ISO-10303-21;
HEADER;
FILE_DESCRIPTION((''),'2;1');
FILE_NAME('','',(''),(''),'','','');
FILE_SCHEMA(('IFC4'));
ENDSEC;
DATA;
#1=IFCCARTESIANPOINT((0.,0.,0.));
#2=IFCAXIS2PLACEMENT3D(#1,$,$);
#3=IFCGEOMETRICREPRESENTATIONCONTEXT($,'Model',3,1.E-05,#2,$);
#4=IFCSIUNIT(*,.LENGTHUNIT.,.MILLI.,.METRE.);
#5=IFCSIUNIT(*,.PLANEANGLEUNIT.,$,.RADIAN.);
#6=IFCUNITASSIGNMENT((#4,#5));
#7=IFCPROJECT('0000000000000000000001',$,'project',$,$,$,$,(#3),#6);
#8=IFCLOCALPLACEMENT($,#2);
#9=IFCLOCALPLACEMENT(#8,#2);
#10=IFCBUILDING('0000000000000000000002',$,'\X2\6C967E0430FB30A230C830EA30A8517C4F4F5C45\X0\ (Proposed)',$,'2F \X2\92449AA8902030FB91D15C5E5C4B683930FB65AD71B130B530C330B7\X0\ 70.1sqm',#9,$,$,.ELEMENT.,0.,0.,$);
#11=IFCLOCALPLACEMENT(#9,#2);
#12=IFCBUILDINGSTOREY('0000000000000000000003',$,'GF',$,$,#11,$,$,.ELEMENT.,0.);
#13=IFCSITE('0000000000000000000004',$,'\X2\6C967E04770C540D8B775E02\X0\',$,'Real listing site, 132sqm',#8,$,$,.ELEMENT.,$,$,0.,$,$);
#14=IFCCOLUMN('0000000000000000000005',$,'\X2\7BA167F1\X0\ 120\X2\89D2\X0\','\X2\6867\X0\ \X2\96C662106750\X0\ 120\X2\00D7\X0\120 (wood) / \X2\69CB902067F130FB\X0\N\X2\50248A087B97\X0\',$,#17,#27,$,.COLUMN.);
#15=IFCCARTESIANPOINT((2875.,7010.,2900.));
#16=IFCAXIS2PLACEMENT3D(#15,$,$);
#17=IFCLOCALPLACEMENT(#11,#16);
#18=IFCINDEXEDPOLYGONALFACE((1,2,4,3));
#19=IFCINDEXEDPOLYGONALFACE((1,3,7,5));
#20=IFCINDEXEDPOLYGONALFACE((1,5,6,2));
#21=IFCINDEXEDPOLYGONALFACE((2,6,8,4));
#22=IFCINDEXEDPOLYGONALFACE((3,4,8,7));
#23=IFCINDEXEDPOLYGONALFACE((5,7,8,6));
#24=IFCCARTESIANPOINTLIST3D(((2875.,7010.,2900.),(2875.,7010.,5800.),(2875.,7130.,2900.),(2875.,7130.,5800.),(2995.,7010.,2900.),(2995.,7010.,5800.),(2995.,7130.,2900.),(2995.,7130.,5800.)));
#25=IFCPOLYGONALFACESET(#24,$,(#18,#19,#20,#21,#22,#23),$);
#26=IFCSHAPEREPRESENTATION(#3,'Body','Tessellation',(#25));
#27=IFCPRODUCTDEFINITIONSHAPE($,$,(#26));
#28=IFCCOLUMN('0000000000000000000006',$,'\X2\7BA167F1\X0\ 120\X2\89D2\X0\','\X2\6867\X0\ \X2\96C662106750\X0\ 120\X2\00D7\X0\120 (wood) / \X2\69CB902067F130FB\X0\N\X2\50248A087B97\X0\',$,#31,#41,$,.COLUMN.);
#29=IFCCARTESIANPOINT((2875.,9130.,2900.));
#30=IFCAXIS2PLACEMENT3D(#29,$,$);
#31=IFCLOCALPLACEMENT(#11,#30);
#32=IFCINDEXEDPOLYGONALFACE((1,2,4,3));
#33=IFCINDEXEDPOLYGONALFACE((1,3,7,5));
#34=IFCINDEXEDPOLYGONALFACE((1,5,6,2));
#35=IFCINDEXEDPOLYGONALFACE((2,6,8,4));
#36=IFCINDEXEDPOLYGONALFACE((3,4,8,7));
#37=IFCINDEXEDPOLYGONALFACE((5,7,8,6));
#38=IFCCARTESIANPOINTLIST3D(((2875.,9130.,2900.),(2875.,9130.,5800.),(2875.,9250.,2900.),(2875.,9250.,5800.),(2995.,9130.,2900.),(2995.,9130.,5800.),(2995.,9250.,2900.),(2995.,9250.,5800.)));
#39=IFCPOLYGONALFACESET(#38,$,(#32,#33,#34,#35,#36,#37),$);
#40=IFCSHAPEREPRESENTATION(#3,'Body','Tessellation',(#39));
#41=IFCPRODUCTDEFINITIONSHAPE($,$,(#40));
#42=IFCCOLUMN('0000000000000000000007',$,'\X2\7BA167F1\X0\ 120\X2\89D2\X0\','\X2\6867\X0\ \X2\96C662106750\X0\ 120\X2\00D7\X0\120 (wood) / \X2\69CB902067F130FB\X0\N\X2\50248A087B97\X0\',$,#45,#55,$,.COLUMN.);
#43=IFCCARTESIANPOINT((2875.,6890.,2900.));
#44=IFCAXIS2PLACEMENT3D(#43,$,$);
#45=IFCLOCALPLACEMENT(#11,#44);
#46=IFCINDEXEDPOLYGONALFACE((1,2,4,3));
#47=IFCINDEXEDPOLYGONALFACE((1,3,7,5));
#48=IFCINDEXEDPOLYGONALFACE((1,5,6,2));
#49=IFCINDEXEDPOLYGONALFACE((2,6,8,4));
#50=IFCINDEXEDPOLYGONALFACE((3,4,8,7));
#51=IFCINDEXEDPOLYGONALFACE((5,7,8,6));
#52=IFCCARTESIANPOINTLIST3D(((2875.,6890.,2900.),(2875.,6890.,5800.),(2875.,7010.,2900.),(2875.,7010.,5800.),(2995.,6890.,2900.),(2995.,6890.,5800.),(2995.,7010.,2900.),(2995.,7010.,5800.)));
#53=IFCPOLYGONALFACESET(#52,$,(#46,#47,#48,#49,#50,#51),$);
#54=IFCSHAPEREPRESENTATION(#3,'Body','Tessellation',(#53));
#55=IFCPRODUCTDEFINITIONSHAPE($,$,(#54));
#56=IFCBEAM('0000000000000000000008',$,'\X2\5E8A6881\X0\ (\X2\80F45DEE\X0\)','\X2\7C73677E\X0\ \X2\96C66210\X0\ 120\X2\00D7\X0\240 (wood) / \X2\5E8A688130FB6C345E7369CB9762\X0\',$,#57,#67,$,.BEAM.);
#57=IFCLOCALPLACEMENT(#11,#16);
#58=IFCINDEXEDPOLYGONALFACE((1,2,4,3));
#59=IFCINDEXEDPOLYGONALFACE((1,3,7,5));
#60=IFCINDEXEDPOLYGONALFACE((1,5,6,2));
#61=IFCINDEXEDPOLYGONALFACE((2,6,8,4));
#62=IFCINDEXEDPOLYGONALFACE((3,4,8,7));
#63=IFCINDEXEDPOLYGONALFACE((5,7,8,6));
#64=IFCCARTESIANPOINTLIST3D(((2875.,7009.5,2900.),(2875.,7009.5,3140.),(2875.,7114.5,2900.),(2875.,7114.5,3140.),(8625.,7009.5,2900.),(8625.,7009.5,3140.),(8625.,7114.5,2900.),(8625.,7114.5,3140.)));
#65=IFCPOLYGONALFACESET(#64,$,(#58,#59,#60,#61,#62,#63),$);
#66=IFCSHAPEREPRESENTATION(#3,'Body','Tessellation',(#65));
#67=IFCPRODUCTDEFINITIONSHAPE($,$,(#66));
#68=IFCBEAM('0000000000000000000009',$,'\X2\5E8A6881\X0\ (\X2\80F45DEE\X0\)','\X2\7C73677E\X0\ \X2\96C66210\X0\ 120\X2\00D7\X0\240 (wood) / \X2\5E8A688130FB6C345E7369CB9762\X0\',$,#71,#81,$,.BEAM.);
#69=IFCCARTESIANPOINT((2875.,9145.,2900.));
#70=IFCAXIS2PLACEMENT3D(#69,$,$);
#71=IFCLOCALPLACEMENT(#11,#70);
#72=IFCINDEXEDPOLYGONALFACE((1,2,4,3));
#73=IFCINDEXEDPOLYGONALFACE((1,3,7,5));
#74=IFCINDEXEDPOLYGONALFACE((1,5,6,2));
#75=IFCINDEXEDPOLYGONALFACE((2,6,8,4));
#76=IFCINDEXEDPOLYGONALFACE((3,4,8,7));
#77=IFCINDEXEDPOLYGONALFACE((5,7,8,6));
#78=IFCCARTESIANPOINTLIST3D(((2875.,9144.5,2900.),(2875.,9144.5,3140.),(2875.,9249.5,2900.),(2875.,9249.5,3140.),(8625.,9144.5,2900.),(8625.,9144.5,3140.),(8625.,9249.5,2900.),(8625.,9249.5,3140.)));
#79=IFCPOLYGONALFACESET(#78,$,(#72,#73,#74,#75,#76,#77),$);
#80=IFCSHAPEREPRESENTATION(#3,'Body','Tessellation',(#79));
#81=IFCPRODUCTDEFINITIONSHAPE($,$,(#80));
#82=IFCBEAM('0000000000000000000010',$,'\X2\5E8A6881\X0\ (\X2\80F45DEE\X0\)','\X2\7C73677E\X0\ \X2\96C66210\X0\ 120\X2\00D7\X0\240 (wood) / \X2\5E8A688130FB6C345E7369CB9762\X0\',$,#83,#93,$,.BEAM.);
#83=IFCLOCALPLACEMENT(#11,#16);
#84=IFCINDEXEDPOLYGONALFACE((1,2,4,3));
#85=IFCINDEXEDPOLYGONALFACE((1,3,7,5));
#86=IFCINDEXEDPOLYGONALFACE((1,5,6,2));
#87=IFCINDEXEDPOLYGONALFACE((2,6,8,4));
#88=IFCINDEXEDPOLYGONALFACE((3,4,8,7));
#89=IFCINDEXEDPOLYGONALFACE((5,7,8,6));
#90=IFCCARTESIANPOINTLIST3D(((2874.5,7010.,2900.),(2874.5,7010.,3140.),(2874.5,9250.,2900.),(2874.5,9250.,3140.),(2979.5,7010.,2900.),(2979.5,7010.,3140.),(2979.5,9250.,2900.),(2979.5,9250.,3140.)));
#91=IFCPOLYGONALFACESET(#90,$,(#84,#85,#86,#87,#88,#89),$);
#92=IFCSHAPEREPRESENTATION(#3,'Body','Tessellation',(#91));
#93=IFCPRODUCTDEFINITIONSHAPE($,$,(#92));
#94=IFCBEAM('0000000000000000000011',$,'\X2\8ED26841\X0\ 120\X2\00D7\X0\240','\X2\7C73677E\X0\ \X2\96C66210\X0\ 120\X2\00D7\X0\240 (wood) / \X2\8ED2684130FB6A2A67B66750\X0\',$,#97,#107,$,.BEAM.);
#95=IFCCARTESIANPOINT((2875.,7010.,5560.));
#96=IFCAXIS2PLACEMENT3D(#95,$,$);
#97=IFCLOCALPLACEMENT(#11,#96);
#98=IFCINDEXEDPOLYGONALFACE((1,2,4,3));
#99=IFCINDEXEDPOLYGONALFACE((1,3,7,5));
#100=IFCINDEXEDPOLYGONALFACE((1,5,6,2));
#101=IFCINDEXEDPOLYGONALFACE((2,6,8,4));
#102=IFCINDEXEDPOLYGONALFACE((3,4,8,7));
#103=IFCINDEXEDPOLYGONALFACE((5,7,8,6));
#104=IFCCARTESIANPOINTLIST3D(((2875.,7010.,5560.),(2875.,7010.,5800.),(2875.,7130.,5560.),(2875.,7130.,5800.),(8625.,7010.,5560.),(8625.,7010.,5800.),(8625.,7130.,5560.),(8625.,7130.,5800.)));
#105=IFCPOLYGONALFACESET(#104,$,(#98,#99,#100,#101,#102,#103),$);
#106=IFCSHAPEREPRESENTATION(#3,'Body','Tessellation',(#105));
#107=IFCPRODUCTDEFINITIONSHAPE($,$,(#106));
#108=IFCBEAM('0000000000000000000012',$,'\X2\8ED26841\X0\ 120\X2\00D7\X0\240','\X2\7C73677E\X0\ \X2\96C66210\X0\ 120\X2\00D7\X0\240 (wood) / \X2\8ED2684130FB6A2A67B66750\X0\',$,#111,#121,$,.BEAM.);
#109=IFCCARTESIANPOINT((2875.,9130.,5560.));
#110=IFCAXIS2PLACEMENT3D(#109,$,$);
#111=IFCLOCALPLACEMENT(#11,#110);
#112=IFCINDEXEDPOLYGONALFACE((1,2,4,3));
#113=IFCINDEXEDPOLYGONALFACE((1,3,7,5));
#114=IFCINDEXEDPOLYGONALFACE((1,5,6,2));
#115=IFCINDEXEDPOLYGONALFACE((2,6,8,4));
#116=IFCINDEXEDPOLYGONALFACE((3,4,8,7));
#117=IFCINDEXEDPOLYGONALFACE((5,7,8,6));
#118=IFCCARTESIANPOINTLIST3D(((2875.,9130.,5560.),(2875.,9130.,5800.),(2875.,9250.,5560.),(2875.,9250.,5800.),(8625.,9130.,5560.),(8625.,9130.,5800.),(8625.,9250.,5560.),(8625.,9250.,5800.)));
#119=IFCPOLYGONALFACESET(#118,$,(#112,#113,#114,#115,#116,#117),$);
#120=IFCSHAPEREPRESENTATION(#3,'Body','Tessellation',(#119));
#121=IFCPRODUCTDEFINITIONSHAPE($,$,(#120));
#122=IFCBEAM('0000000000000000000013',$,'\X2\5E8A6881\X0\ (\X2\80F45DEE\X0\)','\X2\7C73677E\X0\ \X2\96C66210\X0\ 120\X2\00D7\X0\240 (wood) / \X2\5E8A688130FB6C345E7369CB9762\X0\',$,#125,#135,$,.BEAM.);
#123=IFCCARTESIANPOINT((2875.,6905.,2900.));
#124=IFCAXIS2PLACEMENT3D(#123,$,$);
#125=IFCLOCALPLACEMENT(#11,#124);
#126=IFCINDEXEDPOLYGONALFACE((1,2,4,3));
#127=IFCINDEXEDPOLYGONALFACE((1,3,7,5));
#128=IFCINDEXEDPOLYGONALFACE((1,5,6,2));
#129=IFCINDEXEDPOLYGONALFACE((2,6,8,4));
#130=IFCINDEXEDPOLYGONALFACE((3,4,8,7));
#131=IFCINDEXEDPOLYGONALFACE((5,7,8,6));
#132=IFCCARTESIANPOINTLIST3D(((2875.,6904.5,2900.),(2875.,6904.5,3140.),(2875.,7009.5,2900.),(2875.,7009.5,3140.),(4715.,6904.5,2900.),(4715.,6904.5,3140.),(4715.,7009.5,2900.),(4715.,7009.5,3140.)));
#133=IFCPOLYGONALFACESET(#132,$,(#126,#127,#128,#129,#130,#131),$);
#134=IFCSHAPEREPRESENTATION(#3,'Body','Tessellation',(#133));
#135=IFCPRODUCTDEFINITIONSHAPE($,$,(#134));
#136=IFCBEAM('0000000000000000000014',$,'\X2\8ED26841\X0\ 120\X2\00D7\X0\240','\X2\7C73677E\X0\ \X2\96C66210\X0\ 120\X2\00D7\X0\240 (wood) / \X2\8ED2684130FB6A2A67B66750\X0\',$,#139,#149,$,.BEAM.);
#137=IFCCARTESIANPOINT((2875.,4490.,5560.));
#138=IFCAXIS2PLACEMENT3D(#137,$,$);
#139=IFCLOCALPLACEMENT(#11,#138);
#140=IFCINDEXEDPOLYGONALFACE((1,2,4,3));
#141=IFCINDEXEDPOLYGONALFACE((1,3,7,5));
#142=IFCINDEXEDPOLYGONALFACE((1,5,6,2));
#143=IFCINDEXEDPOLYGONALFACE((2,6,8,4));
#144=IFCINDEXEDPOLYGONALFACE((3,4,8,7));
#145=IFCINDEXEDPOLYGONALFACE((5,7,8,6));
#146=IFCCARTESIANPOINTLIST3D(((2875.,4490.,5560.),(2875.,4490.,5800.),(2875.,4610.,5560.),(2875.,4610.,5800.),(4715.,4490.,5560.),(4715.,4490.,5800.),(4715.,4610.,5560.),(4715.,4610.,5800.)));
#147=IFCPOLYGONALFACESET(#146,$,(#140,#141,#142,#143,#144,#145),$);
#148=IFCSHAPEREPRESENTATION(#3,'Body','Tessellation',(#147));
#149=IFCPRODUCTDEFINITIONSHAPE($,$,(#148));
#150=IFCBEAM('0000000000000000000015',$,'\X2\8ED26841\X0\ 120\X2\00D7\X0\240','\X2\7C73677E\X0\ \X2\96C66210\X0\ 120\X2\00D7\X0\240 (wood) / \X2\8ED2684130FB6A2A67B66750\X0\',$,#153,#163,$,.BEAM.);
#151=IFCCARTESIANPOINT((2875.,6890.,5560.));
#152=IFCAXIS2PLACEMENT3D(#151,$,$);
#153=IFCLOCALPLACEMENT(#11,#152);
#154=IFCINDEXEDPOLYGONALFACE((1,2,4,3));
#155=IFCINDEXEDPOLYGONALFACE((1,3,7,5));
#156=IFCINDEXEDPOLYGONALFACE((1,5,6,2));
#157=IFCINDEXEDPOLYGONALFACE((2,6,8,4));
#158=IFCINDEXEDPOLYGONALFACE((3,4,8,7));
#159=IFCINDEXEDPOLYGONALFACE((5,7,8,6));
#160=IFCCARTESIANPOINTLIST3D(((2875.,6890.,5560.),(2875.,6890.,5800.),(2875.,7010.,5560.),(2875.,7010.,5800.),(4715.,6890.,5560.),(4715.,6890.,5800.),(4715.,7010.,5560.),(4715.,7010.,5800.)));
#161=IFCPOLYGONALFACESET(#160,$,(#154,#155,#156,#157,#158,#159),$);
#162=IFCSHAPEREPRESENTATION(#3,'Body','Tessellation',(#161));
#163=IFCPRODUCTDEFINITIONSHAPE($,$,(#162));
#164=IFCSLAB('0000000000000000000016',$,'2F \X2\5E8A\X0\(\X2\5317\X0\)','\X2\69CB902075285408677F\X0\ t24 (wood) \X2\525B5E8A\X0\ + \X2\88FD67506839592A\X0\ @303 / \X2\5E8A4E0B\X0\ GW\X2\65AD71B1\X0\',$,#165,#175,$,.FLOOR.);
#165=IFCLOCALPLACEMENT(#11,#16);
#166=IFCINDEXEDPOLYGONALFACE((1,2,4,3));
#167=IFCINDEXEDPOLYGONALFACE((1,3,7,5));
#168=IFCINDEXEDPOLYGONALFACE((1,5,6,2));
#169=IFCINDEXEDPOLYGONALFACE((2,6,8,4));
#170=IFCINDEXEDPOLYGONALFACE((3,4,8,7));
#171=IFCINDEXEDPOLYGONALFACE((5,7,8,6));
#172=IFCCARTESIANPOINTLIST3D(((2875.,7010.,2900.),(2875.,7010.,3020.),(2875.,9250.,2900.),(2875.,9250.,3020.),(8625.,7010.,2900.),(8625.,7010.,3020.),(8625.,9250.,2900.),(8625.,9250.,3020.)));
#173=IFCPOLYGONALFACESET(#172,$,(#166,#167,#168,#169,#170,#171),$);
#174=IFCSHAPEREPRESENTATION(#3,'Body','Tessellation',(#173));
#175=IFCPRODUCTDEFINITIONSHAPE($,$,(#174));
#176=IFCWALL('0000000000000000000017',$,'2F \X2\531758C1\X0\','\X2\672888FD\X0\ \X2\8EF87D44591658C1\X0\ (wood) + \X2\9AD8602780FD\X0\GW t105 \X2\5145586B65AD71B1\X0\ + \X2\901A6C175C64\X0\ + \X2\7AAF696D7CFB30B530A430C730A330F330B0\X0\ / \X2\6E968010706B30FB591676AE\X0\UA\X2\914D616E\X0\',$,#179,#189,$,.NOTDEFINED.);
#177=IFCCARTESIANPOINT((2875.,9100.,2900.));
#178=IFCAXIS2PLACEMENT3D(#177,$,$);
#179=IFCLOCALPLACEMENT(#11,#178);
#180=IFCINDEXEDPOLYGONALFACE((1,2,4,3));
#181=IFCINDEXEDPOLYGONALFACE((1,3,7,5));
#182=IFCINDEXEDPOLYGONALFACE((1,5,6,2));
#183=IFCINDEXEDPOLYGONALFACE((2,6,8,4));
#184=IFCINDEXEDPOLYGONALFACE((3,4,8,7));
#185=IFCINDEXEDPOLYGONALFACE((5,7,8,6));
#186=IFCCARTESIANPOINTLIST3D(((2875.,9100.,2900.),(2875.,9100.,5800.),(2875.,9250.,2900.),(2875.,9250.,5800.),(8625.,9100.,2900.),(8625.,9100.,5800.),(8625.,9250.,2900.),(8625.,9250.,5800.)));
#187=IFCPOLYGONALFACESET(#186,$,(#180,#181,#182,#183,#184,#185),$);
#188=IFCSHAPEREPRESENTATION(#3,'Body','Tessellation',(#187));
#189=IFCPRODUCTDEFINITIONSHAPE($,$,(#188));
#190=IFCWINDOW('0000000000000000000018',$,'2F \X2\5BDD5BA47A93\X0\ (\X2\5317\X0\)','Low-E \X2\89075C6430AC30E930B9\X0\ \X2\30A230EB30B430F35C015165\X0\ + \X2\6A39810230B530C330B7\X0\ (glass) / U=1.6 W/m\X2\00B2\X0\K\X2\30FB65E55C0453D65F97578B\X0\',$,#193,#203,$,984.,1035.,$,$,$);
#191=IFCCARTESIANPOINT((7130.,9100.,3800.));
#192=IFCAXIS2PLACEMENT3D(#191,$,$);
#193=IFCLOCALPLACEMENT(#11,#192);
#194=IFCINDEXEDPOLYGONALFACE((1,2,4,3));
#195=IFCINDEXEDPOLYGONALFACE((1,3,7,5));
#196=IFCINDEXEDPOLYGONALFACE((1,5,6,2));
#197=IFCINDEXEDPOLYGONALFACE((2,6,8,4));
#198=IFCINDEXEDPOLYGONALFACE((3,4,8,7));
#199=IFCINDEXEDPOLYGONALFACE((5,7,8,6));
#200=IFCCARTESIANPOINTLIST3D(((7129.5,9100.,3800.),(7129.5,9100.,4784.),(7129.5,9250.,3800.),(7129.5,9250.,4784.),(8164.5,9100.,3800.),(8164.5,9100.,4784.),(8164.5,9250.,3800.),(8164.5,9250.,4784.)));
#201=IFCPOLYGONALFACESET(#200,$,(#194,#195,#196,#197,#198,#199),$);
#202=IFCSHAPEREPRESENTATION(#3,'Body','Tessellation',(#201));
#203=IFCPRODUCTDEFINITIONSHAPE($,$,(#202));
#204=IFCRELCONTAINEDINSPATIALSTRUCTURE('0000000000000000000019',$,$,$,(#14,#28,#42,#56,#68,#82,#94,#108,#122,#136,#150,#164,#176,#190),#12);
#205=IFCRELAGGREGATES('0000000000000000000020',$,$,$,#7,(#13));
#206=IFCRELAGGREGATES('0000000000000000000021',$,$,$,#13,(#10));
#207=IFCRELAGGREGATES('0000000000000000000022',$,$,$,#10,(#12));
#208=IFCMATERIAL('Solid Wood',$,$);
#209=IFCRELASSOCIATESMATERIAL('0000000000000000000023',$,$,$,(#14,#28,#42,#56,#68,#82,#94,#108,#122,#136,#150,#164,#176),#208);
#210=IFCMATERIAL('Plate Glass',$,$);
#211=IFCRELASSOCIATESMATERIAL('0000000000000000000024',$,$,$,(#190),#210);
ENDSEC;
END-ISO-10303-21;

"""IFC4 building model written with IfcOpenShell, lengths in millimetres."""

from ifc_helpers import new_model, si_unit, frame, frame_2d, origin, place, context, project, spatial, rectangle, extrude, material, element, fill, save


model = new_model("IFC4")

# Units and contexts
model_context = context("Model", 3, precision=1e-05, world=origin())
ifc_project = project(units=[si_unit("LENGTHUNIT", "METRE", prefix="MILLI"), si_unit("PLANEANGLEUNIT", "RADIAN")], contexts=[model_context])

# Site, building, storey
site_placement = place(None, origin())
site = spatial("IfcSite", under=ifc_project, at=site_placement, Name="沖縄県名護市", ObjectType="Real listing site, 132sqm", CompositionType="ELEMENT", RefElevation=0.0)
building_placement = place(site_placement, origin())
building = spatial("IfcBuilding", under=site, at=building_placement, Name="沖縄・アトリエ兼住居 (Proposed)", ObjectType="2F 鉄骨造・金属屋根・断熱サッシ 70.1sqm", CompositionType="ELEMENT", ElevationOfRefHeight=0.0, ElevationOfTerrain=0.0)
storey_placement = place(building_placement, origin())
storey = spatial("IfcBuildingStorey", under=building, at=storey_placement, Name="GF", CompositionType="ELEMENT", Elevation=0.0)

# Columns
ifc_material_1 = material(Name="Solid Wood")
column_1_placement = place(storey_placement, frame((2875.0, 7010.0, 2900.0)))
element("IfcColumn", 1, at=column_1_placement, inside=storey, material=ifc_material_1, Name="管柱 120角", Description="桧 集成材 120×120 (wood) / 構造柱・N値計算", PredefinedType="COLUMN", context=model_context, shape_type="SweptSolid", body=[
    extrude(rectangle(XDim=120.0, YDim=120.0, at=frame_2d((60.0, 60.0))), frame((2875.0, 7010.0, 2900.0)), (0.0, 0.0, 1.0), 2900.0),
])
column_2_placement = place(storey_placement, frame((2875.0, 9130.0, 2900.0)))
element("IfcColumn", 2, at=column_2_placement, inside=storey, material=ifc_material_1, Name="管柱 120角", Description="桧 集成材 120×120 (wood) / 構造柱・N値計算", PredefinedType="COLUMN", context=model_context, shape_type="SweptSolid", body=[
    extrude(rectangle(XDim=120.0, YDim=120.0, at=frame_2d((60.0, 60.0))), frame((2875.0, 9130.0, 2900.0)), (0.0, 0.0, 1.0), 2900.0),
])
column_3_placement = place(storey_placement, frame((2875.0, 6890.0, 2900.0)))
element("IfcColumn", 3, at=column_3_placement, inside=storey, material=ifc_material_1, Name="管柱 120角", Description="桧 集成材 120×120 (wood) / 構造柱・N値計算", PredefinedType="COLUMN", context=model_context, shape_type="SweptSolid", body=[
    extrude(rectangle(XDim=120.0, YDim=120.0, at=frame_2d((60.0, 60.0))), frame((2875.0, 6890.0, 2900.0)), (0.0, 0.0, 1.0), 2900.0),
])

# Beams
beam_1_placement = place(storey_placement, frame((2875.0, 7010.0, 2900.0)))
element("IfcBeam", 4, at=beam_1_placement, inside=storey, material=ifc_material_1, Name="床梁 (胴差)", Description="米松 集成 120×240 (wood) / 床梁・水平構面", PredefinedType="BEAM", context=model_context, shape_type="SweptSolid", body=[
    extrude(rectangle(XDim=5750.0, YDim=105.0, at=frame_2d((2875.0, 52.0))), frame((2875.0, 7010.0, 2900.0)), (0.0, 0.0, 1.0), 240.0),
])
beam_2_placement = place(storey_placement, frame((2875.0, 9145.0, 2900.0)))
element("IfcBeam", 5, at=beam_2_placement, inside=storey, material=ifc_material_1, Name="床梁 (胴差)", Description="米松 集成 120×240 (wood) / 床梁・水平構面", PredefinedType="BEAM", context=model_context, shape_type="SweptSolid", body=[
    extrude(rectangle(XDim=5750.0, YDim=105.0, at=frame_2d((2875.0, 52.0))), frame((2875.0, 9145.0, 2900.0)), (0.0, 0.0, 1.0), 240.0),
])
beam_3_placement = place(storey_placement, frame((2875.0, 7010.0, 2900.0)))
element("IfcBeam", 6, at=beam_3_placement, inside=storey, material=ifc_material_1, Name="床梁 (胴差)", Description="米松 集成 120×240 (wood) / 床梁・水平構面", PredefinedType="BEAM", context=model_context, shape_type="SweptSolid", body=[
    extrude(rectangle(XDim=105.0, YDim=2240.0, at=frame_2d((52.0, 1120.0))), frame((2875.0, 7010.0, 2900.0)), (0.0, 0.0, 1.0), 240.0),
])
beam_4_placement = place(storey_placement, frame((2875.0, 7010.0, 5560.0)))
element("IfcBeam", 7, at=beam_4_placement, inside=storey, material=ifc_material_1, Name="軒桁 120×240", Description="米松 集成 120×240 (wood) / 軒桁・横架材", PredefinedType="BEAM", context=model_context, shape_type="SweptSolid", body=[
    extrude(rectangle(XDim=5750.0, YDim=120.0, at=frame_2d((2875.0, 60.0))), frame((2875.0, 7010.0, 5560.0)), (0.0, 0.0, 1.0), 240.0),
])
beam_5_placement = place(storey_placement, frame((2875.0, 9130.0, 5560.0)))
element("IfcBeam", 8, at=beam_5_placement, inside=storey, material=ifc_material_1, Name="軒桁 120×240", Description="米松 集成 120×240 (wood) / 軒桁・横架材", PredefinedType="BEAM", context=model_context, shape_type="SweptSolid", body=[
    extrude(rectangle(XDim=5750.0, YDim=120.0, at=frame_2d((2875.0, 60.0))), frame((2875.0, 9130.0, 5560.0)), (0.0, 0.0, 1.0), 240.0),
])
beam_6_placement = place(storey_placement, frame((2875.0, 6905.0, 2900.0)))
element("IfcBeam", 9, at=beam_6_placement, inside=storey, material=ifc_material_1, Name="床梁 (胴差)", Description="米松 集成 120×240 (wood) / 床梁・水平構面", PredefinedType="BEAM", context=model_context, shape_type="SweptSolid", body=[
    extrude(rectangle(XDim=1840.0, YDim=105.0, at=frame_2d((920.0, 52.0))), frame((2875.0, 6905.0, 2900.0)), (0.0, 0.0, 1.0), 240.0),
])
beam_7_placement = place(storey_placement, frame((2875.0, 4490.0, 5560.0)))
element("IfcBeam", 10, at=beam_7_placement, inside=storey, material=ifc_material_1, Name="軒桁 120×240", Description="米松 集成 120×240 (wood) / 軒桁・横架材", PredefinedType="BEAM", context=model_context, shape_type="SweptSolid", body=[
    extrude(rectangle(XDim=1840.0, YDim=120.0, at=frame_2d((920.0, 60.0))), frame((2875.0, 4490.0, 5560.0)), (0.0, 0.0, 1.0), 240.0),
])
beam_8_placement = place(storey_placement, frame((2875.0, 6890.0, 5560.0)))
element("IfcBeam", 11, at=beam_8_placement, inside=storey, material=ifc_material_1, Name="軒桁 120×240", Description="米松 集成 120×240 (wood) / 軒桁・横架材", PredefinedType="BEAM", context=model_context, shape_type="SweptSolid", body=[
    extrude(rectangle(XDim=1840.0, YDim=120.0, at=frame_2d((920.0, 60.0))), frame((2875.0, 6890.0, 5560.0)), (0.0, 0.0, 1.0), 240.0),
])

# Slab
slab_placement = place(storey_placement, frame((2875.0, 7010.0, 2900.0)))
element("IfcSlab", 12, at=slab_placement, inside=storey, material=ifc_material_1, Name="2F 床(北)", Description="構造用合板 t24 (wood) 剛床 + 製材根太 @303 / 床下 GW断熱", PredefinedType="FLOOR", context=model_context, shape_type="SweptSolid", body=[
    extrude(rectangle(XDim=5750.0, YDim=2240.0, at=frame_2d((2875.0, 1120.0))), frame((2875.0, 7010.0, 2900.0)), (0.0, 0.0, 1.0), 120.0),
])

# Wall, opening, window
wall_placement = place(storey_placement, frame((2875.0, 9100.0, 2900.0)))
wall = element("IfcWall", 13, at=wall_placement, inside=storey, material=ifc_material_1, Name="2F 北壁", Description="木製 軸組外壁 (wood) + 高性能GW t105 充填断熱 + 通気層 + 窯業系サイディング / 準耐火・外皮UA配慮", PredefinedType="NOTDEFINED", context=model_context, shape_type="SweptSolid", body=[
    extrude(rectangle(XDim=5750.0, YDim=150.0, at=frame_2d((2875.0, 75.0))), frame((2875.0, 9100.0, 2900.0)), (0.0, 0.0, 1.0), 2900.0),
])
opening_placement = place(storey_placement, frame((7130.0, 9100.0, 3800.0)))
opening = element("IfcOpeningElement", 14, at=opening_placement, cuts=wall, PredefinedType="NOTDEFINED", context=model_context, shape_type="SweptSolid", body=[
    extrude(rectangle(XDim=1035.0, YDim=150.0, at=frame_2d((517.0, 75.0))), frame((7130.0, 9100.0, 3800.0)), (0.0, 0.0, 1.0), 984.0),
])
ifc_material_2 = material(Name="Plate Glass")
window_placement = place(storey_placement, frame((7130.0, 9100.0, 3800.0)))
window = element("IfcWindow", 15, at=window_placement, inside=storey, material=ifc_material_2, Name="2F 寝室窓 (北)", Description="Low-E 複層ガラス アルゴン封入 + 樹脂サッシ (glass) / U=1.6 W/m²K・日射取得型", OverallHeight=984.0, OverallWidth=1035.0, context=model_context, shape_type="SweptSolid", body=[
    extrude(rectangle(XDim=1035.0, YDim=150.0, at=frame_2d((517.0, 75.0))), frame((7130.0, 9100.0, 3800.0)), (0.0, 0.0, 1.0), 984.0),
])
fill(opening, window)

save(model, "model.ifc")
